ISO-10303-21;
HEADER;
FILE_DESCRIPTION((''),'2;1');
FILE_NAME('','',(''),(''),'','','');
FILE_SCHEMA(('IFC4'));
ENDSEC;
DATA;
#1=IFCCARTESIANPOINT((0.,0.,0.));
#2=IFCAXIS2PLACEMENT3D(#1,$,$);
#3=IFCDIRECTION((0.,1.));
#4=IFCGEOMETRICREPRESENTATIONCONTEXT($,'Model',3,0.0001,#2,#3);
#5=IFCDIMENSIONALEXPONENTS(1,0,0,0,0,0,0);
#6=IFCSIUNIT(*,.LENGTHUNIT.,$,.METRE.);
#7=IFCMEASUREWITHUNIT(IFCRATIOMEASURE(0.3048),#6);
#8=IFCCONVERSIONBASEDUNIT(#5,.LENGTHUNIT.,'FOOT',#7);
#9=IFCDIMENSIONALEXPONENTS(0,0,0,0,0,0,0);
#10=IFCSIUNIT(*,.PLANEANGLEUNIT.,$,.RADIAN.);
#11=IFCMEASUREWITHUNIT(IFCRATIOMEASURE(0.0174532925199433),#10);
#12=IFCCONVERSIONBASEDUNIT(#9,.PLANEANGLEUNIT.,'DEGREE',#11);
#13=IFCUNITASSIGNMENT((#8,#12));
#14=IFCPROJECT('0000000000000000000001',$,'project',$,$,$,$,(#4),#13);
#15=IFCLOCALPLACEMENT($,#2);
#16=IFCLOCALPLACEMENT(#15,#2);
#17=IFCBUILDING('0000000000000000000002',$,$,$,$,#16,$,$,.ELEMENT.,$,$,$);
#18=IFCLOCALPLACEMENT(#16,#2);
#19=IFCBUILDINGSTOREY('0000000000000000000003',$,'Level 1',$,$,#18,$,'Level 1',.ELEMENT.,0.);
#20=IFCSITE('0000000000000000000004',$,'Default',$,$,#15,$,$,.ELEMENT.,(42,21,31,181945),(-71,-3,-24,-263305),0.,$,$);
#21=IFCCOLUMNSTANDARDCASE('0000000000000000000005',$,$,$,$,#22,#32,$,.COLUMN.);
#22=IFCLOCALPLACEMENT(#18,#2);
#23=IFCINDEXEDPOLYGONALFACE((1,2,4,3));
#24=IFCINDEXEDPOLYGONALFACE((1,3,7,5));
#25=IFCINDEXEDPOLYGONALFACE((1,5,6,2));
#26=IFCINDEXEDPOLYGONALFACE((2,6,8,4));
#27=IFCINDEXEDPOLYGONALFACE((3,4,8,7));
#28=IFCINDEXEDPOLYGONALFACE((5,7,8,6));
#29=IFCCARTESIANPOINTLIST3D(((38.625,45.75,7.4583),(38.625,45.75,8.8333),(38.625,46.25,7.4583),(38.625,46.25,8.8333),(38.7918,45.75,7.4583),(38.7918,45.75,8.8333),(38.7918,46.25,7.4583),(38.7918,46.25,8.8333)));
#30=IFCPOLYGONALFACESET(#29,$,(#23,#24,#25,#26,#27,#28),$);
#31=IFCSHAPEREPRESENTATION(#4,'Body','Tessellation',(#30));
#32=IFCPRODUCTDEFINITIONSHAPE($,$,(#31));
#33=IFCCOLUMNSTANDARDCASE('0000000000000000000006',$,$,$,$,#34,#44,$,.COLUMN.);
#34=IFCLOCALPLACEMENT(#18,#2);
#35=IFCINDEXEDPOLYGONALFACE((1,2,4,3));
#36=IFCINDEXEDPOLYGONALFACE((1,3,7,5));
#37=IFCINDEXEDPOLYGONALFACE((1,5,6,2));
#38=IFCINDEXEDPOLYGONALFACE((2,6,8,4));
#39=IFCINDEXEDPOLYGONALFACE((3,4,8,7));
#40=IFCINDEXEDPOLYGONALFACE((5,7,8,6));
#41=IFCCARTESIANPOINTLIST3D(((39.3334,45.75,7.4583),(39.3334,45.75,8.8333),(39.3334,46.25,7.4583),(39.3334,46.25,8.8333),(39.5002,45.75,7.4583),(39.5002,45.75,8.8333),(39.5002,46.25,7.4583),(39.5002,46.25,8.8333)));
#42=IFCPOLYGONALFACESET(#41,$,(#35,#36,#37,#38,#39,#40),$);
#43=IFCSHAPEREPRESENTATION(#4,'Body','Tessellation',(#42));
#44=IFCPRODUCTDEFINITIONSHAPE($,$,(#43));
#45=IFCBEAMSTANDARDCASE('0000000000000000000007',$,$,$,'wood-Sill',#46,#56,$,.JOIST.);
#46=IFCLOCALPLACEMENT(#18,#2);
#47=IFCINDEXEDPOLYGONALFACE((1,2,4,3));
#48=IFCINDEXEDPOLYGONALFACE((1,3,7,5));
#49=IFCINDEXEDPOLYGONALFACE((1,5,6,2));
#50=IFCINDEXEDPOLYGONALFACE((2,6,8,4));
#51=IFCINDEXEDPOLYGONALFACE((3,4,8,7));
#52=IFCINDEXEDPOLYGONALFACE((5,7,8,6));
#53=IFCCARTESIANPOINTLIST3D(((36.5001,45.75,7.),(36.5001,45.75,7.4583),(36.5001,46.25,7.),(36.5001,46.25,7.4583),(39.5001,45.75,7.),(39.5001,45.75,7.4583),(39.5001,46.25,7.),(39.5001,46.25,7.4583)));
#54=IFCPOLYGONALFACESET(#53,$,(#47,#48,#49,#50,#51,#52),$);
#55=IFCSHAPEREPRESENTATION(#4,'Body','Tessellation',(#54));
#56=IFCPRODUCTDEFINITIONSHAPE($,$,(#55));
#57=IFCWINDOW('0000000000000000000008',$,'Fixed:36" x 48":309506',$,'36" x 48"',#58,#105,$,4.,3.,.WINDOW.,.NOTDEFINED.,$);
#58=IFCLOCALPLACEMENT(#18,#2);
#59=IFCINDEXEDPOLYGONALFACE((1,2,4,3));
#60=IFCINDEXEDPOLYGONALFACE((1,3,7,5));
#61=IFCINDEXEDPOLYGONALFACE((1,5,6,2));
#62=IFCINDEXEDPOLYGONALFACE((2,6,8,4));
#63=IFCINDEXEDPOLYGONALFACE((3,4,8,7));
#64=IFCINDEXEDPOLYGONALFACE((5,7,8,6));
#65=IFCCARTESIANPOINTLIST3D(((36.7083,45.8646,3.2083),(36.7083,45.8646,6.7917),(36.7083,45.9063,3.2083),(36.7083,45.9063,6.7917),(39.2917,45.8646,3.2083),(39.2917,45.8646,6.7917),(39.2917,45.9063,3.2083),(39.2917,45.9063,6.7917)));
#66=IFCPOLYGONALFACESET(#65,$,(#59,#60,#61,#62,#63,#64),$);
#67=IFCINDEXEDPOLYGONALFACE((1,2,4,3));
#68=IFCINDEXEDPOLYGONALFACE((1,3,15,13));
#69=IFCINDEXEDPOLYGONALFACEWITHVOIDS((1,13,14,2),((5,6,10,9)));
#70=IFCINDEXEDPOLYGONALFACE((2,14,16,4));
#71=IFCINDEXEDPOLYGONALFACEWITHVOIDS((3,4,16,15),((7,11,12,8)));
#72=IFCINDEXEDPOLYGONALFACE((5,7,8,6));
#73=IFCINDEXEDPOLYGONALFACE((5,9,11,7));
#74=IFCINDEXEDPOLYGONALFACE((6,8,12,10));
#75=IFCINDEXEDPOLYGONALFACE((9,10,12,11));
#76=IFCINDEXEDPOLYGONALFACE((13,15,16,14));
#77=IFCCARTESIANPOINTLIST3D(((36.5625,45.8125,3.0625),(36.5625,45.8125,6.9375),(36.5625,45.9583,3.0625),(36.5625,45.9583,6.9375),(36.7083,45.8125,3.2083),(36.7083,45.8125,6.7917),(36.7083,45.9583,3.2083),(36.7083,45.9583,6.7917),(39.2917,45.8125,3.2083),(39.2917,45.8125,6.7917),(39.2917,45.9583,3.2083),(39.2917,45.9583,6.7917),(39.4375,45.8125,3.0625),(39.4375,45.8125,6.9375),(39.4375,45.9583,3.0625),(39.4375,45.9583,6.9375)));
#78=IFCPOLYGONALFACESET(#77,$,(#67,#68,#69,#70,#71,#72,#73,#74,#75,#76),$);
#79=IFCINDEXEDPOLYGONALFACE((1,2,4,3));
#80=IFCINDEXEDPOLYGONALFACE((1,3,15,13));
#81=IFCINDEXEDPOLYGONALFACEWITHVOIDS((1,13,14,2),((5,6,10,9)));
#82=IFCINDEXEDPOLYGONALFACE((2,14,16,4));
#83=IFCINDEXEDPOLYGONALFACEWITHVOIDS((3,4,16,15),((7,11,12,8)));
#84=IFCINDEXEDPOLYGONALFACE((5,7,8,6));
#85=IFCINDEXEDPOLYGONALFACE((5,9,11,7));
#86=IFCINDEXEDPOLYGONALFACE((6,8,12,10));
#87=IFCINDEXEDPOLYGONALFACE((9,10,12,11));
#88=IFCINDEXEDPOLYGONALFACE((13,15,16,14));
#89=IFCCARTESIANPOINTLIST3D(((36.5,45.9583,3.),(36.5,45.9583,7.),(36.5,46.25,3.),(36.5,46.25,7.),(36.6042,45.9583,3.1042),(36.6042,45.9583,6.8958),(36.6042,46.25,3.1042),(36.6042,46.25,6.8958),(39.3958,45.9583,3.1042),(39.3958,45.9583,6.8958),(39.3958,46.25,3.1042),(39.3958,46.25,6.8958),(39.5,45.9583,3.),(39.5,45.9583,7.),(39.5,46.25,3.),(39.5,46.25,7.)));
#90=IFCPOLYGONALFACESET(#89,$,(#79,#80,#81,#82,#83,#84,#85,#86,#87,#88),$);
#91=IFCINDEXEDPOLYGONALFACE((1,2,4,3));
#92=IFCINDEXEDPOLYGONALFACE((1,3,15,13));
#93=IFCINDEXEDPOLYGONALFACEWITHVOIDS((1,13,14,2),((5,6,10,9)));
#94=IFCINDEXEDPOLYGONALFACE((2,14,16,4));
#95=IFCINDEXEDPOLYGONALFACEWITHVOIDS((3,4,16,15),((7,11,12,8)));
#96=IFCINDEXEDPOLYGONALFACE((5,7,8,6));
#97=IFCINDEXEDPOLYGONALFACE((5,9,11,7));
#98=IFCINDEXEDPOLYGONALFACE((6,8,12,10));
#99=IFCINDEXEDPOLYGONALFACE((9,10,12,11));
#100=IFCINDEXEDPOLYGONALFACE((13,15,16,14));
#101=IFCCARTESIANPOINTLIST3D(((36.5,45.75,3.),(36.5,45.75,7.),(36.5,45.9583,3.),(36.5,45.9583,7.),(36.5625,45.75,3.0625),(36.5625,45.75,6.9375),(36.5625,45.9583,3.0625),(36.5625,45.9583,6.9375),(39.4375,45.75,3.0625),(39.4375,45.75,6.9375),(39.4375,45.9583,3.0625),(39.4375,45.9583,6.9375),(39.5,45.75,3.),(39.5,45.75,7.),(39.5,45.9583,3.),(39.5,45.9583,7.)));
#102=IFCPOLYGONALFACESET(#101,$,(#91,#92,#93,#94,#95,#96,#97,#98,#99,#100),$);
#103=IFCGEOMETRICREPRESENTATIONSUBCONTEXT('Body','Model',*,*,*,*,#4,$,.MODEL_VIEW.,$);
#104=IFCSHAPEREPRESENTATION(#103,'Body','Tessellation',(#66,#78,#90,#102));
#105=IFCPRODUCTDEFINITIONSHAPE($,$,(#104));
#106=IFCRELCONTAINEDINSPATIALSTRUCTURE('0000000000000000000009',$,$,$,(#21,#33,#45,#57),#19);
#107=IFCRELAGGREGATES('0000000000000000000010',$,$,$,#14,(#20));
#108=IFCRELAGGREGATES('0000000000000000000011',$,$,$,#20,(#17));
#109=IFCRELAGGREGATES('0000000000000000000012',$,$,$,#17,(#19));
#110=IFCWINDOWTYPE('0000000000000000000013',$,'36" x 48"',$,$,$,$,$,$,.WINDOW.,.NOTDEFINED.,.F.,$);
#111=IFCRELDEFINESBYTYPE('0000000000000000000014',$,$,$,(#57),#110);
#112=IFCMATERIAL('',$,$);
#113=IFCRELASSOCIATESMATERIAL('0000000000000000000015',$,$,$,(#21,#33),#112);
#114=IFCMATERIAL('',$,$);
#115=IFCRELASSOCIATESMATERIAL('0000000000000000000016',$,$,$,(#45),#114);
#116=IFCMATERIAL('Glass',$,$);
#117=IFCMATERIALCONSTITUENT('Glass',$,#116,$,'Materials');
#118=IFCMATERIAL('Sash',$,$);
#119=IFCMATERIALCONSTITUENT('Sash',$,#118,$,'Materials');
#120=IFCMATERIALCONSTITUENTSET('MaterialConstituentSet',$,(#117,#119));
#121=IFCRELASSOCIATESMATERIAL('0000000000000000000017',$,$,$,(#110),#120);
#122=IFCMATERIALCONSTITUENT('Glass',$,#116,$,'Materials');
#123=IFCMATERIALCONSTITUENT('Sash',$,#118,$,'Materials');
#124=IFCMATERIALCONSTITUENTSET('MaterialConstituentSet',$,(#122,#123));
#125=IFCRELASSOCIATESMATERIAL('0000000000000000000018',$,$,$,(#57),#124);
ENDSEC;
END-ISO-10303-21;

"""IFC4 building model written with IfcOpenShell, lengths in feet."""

from ifc_helpers import new_model, entity, si_unit, converted_unit, direction, frame, frame_2d, origin, place, context, subcontext, project, spatial, polyline, rectangle, outline, extrude, source, transform, mapped, material, constituent, constituent_set, type_object, type_shapes, element, save


model = new_model("IFC4")

# Units and contexts
model_context = context("Model", 3, precision=0.0001, world=origin(), true_north=direction((0.0, 1.0)))
body_context = subcontext(model_context, "Body", "Model", "MODEL_VIEW")
ifc_project = project(units=[converted_unit("LENGTHUNIT", "FOOT", entity("IfcRatioMeasure", 0.3048), si_unit("LENGTHUNIT", "METRE"), dimensions=[1, 0, 0, 0, 0, 0, 0]), converted_unit("PLANEANGLEUNIT", "DEGREE", entity("IfcRatioMeasure", 0.0174532925199433), si_unit("PLANEANGLEUNIT", "RADIAN"), dimensions=[0, 0, 0, 0, 0, 0, 0])], contexts=[model_context])

# Site, building, storey
site_placement = place(None, origin())
site = spatial("IfcSite", under=ifc_project, at=site_placement, Name="Default", CompositionType="ELEMENT", RefLatitude=(42, 21, 31, 181945), RefLongitude=(-71, -3, -24, -263305), RefElevation=0.0)
building_placement = place(site_placement, origin())
building = spatial("IfcBuilding", under=site, at=building_placement, CompositionType="ELEMENT")
storey_placement = place(building_placement, origin())
storey = spatial("IfcBuildingStorey", under=building, at=storey_placement, Name="Level 1", LongName="Level 1", CompositionType="ELEMENT", Elevation=0.0)

# Columns
placement_1 = place(storey_placement, frame((-0.25, 46.0, 0.0)))
ifc_material_1 = material(Name="")
for number, where, z_axis, x_axis in (
    (1, (38.9584, 0.0, 7.4583), (0.0, 0.0, 1.0), (1.0, 0.0, 0.0)),
    (2, (39.6668, 0.0, 7.4583), (0.0, 0.0, 1.0), (1.0, 0.0, 0.0)),
):
    element("IfcColumnStandardCase", number, at=place(placement_1, frame(where, z_axis=z_axis, x_axis=x_axis)), inside=storey, material=ifc_material_1, PredefinedType="COLUMN", context=model_context, shape_type="SweptSolid", body=[
        extrude(rectangle(XDim=0.1667, YDim=0.5), origin(), (0.0, 0.0, 1.0), 1.375),
    ])

# Beam
ifc_material_2 = material(Name="")
beam_placement = place(placement_1, frame((38.2501, 0.0, 7.0), z_axis=(0.0, 0.0, 1.0), x_axis=(-1.0, 0.0, 0.0)))
element("IfcBeamStandardCase", 3, at=beam_placement, inside=storey, material=ifc_material_2, ObjectType="wood-Sill", PredefinedType="JOIST", context=model_context, shape_type="SweptSolid", body=[
    extrude(rectangle(XDim=3.0, YDim=0.5), origin(), (0.0, 0.0, 1.0), 0.4583),
])

# Window
ifc_material_3 = material(Name="Glass")
ifc_constituent_1 = constituent(ifc_material_3, Name="Glass", Category="Materials")
ifc_material_4 = material(Name="Sash")
ifc_constituent_2 = constituent(ifc_material_4, Name="Sash", Category="Materials")
ifc_constituent_set_1 = constituent_set(constituents=[ifc_constituent_1, ifc_constituent_2], Name="MaterialConstituentSet")
ifc_constituent_3 = constituent(ifc_material_3, Name="Glass", Category="Materials")
ifc_constituent_4 = constituent(ifc_material_4, Name="Sash", Category="Materials")
ifc_constituent_set_2 = constituent_set(constituents=[ifc_constituent_3, ifc_constituent_4], Name="MaterialConstituentSet")
window_type = type_object("IfcWindowType", Name="36\" x 48\"", ParameterTakesPrecedence=False, PartitioningType="NOTDEFINED", PredefinedType="WINDOW", material=ifc_constituent_set_2)
shared_shape = source(origin(), body_context, "Body", "SweptSolid", [
    extrude(rectangle(XDim=0.0417, YDim=2.5833, at=frame_2d((0.0, 0.0), x_axis=(1.0, 0.0))), frame((1.5, 0.3646, 0.2083), z_axis=(0.0, 0.0, 1.0), x_axis=(0.0, 1.0, 0.0)), (0.0, 0.0, 1.0), 3.5833),
    extrude(outline(polyline([(-1.4375, -1.9375), (1.4375, -1.9375), (1.4375, 1.9375), (-1.4375, 1.9375), (-1.4375, -1.9375)]), holes=[polyline([(-1.2917, -1.7917), (-1.2917, 1.7917), (1.2917, 1.7917), (1.2917, -1.7917), (-1.2917, -1.7917)])]), frame((1.5, 0.2917, 2.0), z_axis=(0.0, 1.0, 0.0), x_axis=(1.0, 0.0, 0.0)), (0.0, 0.0, 1.0), 0.1458),
    extrude(outline(polyline([(-1.5, -2.0), (1.5, -2.0), (1.5, 2.0), (-1.5, 2.0), (-1.5, -2.0)]), holes=[polyline([(-1.3958, -1.8958), (-1.3958, 1.8958), (1.3958, 1.8958), (1.3958, -1.8958), (-1.3958, -1.8958)])]), frame((1.5, 0.0, 2.0), z_axis=(0.0, 1.0, 0.0), x_axis=(1.0, 0.0, 0.0)), (0.0, 0.0, 1.0), 0.2917),
    extrude(outline(polyline([(-2.0, -1.5), (2.0, -1.5), (2.0, 1.5), (-2.0, 1.5), (-2.0, -1.5)]), holes=[polyline([(-1.9375, -1.4375), (-1.9375, 1.4375), (1.9375, 1.4375), (1.9375, -1.4375), (-1.9375, -1.4375)])]), frame((1.5, 0.2917, 2.0), z_axis=(0.0, 1.0, 0.0), x_axis=(0.0, 0.0, -1.0)), (0.0, 0.0, 1.0), 0.2083),
])
type_shapes(window_type, [shared_shape])
placement_2 = place(placement_1, frame((39.75, 0.25, 3.0)))
window_placement = place(placement_2, frame((0.0, 0.0, 0.0), z_axis=(0.0, 0.0, 1.0), x_axis=(-1.0, 0.0, 0.0)))
element("IfcWindow", 4, at=window_placement, inside=storey, type_object=window_type, material=ifc_constituent_set_1, Name="Fixed:36\" x 48\":309506", ObjectType="36\" x 48\"", OverallHeight=4.0, OverallWidth=3.0, PartitioningType="NOTDEFINED", PredefinedType="WINDOW", context=body_context, shape_type="MappedRepresentation", body=[
    mapped(shared_shape, transform((0.0, 0.0, 0.0), scale=1.0)),
])

save(model, "model.ifc")
